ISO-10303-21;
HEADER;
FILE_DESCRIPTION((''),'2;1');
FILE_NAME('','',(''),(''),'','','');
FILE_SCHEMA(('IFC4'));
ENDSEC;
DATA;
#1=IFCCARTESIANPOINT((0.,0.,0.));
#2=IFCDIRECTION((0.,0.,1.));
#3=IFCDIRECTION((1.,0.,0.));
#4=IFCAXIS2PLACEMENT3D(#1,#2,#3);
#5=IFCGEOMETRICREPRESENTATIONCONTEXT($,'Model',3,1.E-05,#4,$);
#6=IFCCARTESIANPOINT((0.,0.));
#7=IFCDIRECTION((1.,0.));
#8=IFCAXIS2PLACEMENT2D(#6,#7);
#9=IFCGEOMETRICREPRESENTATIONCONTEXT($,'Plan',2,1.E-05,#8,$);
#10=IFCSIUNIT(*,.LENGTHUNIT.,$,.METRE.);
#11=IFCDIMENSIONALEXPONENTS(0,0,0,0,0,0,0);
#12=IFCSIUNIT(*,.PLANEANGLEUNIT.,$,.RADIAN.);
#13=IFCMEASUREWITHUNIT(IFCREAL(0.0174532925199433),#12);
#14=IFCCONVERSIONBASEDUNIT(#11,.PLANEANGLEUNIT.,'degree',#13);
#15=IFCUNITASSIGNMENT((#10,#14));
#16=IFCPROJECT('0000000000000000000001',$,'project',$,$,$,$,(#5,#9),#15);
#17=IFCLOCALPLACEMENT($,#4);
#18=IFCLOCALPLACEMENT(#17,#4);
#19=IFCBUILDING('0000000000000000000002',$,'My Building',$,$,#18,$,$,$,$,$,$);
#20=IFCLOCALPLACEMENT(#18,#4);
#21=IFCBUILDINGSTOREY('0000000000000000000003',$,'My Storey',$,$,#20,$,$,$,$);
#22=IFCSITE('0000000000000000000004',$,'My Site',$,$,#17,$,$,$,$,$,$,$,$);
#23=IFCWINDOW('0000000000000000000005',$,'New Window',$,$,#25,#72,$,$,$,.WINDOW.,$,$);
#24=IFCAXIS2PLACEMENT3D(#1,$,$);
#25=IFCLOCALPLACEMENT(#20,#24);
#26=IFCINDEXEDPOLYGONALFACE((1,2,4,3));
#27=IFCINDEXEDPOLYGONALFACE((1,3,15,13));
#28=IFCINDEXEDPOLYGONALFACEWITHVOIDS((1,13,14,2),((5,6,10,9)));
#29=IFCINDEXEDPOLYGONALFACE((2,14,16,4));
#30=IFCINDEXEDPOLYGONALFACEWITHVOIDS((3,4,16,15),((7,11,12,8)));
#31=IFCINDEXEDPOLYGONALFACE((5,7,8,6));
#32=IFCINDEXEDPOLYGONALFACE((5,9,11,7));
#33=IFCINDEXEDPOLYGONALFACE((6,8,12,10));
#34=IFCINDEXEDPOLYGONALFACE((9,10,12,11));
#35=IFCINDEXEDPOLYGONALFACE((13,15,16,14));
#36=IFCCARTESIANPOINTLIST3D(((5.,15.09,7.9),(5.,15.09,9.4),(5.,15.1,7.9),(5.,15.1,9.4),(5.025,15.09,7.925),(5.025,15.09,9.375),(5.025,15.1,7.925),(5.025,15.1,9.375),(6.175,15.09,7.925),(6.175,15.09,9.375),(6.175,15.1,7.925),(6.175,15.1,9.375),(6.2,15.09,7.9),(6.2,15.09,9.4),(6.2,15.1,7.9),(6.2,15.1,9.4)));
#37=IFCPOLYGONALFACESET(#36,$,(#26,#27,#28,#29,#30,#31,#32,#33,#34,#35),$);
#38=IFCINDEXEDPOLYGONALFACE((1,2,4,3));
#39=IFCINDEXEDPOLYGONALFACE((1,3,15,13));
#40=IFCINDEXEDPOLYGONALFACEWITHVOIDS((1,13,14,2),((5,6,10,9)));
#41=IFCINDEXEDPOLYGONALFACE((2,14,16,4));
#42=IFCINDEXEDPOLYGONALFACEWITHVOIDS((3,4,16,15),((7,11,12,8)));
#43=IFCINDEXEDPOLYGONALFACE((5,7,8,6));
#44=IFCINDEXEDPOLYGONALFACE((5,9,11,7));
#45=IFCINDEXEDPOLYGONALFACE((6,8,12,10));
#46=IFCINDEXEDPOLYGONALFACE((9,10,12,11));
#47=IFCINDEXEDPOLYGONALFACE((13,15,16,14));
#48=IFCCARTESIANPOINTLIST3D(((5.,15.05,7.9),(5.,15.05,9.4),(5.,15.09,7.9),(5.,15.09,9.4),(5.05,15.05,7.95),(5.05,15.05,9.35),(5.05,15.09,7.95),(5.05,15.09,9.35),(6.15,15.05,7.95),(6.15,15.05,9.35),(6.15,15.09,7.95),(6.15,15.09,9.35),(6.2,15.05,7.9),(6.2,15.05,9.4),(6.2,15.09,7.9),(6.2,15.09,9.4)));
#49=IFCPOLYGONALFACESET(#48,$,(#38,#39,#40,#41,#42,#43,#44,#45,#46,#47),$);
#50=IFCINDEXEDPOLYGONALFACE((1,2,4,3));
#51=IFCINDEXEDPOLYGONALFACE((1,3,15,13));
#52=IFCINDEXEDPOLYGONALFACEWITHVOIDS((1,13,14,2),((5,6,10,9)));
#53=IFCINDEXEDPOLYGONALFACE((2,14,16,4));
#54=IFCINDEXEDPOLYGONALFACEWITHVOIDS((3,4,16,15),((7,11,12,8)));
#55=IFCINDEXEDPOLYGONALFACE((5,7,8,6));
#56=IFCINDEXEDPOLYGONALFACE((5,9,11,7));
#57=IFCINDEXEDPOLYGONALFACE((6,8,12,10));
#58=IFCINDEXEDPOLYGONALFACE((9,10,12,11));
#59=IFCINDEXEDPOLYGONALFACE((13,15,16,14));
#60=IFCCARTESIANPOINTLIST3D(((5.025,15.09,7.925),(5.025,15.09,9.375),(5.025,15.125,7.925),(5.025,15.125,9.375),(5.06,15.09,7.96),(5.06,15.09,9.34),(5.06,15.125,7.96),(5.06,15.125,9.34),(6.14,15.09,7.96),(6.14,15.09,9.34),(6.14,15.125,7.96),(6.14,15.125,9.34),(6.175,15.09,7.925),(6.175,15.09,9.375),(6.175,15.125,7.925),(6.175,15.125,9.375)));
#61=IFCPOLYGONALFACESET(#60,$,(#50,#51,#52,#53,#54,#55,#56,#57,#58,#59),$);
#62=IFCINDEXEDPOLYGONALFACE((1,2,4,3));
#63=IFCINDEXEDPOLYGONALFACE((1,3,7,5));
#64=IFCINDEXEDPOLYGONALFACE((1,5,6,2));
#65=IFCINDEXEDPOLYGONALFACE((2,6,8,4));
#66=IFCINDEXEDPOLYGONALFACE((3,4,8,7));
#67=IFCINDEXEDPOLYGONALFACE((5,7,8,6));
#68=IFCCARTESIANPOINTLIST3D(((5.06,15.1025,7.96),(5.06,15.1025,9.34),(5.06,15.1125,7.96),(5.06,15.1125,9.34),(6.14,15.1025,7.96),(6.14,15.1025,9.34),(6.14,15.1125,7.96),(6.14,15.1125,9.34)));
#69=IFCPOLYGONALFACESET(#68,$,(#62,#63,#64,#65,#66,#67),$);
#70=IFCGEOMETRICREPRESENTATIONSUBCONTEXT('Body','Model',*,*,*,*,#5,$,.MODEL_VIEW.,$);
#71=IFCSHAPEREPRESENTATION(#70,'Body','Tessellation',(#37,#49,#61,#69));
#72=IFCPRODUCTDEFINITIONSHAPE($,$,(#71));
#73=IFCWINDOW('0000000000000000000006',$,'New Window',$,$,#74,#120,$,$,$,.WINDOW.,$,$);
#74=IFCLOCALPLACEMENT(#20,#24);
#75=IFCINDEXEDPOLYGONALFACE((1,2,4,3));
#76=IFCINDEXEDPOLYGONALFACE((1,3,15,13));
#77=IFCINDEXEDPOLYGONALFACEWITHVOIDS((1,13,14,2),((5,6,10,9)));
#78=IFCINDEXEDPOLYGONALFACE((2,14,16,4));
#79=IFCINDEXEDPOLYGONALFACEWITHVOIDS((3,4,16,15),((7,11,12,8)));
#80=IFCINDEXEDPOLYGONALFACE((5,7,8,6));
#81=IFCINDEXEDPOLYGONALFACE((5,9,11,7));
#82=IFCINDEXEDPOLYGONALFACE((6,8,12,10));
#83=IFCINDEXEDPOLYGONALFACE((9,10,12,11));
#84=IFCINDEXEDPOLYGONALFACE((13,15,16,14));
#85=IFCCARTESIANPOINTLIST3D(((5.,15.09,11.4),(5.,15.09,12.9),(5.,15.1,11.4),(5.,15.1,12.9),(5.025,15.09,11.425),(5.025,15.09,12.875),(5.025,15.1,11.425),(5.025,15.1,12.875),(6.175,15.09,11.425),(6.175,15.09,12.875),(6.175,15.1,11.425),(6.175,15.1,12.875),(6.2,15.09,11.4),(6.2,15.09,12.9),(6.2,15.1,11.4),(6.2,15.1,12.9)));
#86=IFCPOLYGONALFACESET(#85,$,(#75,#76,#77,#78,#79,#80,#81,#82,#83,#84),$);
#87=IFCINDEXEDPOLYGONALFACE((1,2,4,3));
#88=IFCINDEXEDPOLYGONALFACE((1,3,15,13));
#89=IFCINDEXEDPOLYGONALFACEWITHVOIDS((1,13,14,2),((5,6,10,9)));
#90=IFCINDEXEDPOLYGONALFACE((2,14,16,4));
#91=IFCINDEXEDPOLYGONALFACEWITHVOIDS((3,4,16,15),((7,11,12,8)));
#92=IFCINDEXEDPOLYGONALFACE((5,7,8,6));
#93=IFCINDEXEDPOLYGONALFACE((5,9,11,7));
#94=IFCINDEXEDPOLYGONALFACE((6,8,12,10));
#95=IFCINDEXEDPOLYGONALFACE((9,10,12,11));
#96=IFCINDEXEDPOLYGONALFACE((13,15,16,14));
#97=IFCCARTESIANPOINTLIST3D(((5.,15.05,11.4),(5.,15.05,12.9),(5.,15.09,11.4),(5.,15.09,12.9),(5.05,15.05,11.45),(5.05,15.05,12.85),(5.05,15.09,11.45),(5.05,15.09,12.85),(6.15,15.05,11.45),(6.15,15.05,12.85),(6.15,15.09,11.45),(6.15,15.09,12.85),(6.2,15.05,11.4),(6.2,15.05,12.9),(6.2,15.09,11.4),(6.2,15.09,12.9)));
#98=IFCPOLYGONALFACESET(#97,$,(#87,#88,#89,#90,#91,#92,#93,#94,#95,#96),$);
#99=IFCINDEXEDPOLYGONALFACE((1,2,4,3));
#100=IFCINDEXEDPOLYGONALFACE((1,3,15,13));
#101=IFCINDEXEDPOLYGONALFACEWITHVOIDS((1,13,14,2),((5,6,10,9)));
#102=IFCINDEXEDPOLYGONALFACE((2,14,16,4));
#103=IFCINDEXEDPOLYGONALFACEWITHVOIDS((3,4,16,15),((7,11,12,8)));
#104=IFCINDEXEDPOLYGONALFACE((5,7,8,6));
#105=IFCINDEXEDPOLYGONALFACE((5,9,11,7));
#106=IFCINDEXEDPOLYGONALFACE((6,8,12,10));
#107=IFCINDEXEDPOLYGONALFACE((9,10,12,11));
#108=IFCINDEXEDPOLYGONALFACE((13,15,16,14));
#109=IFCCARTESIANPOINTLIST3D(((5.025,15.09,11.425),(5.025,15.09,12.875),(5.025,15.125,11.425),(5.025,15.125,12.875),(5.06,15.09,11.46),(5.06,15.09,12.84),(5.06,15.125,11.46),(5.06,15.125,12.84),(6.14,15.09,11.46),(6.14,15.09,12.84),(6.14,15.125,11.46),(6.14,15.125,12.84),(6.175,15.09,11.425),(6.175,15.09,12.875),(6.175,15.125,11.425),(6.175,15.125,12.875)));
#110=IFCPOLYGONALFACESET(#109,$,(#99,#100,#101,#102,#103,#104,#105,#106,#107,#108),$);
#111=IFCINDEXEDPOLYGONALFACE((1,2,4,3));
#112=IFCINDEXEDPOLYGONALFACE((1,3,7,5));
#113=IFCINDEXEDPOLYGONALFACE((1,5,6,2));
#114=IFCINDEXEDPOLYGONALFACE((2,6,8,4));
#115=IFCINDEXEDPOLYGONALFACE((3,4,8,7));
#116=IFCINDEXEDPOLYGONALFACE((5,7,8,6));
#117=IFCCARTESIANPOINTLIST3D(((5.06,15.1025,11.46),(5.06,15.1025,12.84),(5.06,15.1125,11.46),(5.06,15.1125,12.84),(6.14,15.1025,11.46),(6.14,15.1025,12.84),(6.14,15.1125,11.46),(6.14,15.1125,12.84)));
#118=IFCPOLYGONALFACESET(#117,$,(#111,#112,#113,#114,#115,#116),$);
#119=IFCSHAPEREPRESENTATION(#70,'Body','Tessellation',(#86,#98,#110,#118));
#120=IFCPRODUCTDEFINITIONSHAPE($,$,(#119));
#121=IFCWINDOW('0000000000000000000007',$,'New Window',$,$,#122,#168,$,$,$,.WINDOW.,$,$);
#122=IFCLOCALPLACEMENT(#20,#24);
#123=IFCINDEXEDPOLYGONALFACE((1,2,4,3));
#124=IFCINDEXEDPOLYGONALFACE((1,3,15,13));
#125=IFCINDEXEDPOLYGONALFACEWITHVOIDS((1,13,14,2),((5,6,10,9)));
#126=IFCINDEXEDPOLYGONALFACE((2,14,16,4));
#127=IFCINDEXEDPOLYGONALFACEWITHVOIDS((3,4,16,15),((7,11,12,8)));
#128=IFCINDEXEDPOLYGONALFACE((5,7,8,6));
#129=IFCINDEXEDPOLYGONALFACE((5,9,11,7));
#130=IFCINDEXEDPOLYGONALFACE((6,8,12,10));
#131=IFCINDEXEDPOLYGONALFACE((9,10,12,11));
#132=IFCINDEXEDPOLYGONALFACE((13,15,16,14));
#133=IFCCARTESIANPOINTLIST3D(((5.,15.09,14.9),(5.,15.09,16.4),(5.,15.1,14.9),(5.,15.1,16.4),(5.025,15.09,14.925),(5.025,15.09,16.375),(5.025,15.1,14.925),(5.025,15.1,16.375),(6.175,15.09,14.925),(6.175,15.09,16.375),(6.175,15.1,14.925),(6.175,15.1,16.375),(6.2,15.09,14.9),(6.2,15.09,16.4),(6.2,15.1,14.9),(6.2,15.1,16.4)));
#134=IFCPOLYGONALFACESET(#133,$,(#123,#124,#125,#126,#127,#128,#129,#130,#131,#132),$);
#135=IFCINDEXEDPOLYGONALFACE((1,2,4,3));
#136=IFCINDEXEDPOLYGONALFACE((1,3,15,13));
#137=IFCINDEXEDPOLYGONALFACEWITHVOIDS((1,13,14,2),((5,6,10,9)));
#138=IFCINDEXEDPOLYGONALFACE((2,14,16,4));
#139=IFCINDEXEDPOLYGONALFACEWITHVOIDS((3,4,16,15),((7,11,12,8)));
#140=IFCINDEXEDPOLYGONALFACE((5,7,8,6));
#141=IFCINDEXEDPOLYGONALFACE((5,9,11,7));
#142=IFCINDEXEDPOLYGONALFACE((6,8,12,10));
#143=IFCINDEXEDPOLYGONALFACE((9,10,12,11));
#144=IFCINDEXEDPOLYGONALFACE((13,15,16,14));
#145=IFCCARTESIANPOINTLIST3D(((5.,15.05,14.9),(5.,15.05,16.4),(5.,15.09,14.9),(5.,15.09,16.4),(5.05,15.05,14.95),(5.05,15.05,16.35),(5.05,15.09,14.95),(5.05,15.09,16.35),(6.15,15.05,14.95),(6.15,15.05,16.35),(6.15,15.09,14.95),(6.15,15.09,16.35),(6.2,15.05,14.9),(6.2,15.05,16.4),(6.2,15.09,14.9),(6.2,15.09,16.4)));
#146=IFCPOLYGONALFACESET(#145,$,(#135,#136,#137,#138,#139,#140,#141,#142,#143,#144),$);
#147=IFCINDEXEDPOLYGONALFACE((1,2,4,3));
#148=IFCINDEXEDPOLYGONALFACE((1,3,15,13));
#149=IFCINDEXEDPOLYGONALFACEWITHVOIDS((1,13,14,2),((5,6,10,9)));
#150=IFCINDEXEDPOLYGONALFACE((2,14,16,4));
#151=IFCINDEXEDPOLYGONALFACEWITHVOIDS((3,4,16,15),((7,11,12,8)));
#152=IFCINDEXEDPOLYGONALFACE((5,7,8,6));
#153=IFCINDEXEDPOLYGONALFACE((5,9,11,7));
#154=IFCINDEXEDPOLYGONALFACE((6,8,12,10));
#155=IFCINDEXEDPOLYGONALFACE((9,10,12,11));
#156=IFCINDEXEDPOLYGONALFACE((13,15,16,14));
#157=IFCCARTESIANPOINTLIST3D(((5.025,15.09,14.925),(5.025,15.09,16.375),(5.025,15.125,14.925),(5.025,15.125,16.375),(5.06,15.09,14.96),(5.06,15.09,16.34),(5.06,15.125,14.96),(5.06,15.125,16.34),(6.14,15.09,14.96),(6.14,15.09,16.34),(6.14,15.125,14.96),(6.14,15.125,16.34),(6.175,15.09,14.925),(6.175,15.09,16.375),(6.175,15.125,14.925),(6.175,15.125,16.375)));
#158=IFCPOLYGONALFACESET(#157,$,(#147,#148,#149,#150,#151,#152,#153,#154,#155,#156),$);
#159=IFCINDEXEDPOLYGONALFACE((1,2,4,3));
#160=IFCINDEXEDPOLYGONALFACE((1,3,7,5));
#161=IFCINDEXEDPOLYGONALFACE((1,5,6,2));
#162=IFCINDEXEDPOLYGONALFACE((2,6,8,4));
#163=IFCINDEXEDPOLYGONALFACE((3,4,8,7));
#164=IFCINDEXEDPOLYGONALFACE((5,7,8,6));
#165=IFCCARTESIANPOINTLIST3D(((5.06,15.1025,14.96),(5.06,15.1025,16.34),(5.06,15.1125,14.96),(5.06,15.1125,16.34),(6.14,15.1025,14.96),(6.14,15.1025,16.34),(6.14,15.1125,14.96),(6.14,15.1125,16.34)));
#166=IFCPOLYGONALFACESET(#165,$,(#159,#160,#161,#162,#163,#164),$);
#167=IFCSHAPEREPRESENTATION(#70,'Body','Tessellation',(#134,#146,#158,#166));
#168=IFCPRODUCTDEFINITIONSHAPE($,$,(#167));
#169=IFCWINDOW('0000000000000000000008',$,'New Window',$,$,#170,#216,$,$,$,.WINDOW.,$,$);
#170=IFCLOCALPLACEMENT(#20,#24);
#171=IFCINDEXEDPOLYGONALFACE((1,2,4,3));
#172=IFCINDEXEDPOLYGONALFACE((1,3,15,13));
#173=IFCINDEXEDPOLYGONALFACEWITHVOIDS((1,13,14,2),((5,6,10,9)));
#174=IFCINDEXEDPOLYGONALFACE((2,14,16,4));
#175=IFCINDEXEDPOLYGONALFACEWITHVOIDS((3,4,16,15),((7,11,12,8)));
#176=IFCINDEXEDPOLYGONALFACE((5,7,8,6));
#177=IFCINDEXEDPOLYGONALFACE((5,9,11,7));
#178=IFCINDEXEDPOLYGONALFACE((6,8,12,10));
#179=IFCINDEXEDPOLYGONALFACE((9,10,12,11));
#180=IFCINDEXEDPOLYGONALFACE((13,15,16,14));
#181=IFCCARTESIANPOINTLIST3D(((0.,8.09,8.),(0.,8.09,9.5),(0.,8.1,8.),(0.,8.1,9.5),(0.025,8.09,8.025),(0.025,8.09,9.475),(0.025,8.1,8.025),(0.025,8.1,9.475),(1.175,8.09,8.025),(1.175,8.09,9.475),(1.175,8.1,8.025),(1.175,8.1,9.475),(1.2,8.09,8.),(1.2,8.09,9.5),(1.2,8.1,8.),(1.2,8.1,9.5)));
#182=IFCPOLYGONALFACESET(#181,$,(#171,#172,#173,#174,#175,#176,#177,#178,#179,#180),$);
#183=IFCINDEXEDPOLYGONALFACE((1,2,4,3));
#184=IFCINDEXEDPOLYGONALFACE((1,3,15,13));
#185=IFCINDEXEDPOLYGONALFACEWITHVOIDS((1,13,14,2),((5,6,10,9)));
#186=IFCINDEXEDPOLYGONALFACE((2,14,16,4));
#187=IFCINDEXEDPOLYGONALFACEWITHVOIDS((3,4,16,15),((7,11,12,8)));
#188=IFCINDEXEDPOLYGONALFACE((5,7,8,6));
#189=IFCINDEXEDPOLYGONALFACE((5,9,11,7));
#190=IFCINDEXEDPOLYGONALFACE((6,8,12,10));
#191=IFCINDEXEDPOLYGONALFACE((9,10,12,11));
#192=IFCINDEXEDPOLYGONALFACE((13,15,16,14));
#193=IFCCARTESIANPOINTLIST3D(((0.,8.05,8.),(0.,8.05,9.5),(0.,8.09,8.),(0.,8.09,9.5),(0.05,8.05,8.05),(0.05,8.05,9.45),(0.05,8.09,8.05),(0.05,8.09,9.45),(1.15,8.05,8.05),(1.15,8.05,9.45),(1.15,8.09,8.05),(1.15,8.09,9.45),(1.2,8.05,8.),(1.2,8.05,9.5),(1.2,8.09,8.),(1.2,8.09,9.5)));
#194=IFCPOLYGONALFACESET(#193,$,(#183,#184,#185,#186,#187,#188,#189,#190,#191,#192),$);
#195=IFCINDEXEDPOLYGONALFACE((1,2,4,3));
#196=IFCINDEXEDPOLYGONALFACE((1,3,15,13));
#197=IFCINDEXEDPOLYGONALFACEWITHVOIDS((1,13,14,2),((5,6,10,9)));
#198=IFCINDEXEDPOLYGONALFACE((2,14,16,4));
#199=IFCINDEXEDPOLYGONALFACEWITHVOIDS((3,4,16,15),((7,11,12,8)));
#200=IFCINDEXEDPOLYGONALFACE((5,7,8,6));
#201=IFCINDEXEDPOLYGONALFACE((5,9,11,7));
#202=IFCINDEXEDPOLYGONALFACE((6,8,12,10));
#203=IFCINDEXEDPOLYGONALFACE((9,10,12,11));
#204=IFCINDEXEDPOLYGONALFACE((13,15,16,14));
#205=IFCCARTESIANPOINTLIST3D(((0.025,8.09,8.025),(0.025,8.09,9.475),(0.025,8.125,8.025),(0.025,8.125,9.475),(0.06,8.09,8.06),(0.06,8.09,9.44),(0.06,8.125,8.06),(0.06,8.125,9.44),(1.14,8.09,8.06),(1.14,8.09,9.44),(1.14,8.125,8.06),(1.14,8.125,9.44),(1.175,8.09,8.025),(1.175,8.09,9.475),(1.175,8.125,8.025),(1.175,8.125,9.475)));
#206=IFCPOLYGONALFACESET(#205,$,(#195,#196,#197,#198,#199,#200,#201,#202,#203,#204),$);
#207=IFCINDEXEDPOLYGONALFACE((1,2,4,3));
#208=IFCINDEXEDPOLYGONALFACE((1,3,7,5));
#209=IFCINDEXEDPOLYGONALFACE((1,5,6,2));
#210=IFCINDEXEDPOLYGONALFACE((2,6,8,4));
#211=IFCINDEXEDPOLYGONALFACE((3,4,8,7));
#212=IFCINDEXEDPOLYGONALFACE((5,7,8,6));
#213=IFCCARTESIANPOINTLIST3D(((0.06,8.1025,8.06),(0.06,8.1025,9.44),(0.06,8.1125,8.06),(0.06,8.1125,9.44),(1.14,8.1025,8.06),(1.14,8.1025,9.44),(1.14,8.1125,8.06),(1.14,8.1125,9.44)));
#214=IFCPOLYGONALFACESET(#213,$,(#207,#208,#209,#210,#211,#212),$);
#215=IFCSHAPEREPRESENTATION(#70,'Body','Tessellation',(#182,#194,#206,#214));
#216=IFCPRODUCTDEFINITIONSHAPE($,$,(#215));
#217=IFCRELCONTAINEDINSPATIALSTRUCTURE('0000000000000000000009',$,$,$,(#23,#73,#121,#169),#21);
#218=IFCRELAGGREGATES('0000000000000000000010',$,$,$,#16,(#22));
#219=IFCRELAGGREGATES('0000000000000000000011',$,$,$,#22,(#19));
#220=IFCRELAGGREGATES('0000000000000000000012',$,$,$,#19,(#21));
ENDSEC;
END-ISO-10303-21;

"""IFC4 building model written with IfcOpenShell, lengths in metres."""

from ifc_helpers import new_model, entity, si_unit, converted_unit, frame, origin_with_axes, origin_2d_with_axis, place, context, subcontext, project, spatial, line, indexed_curve, outline, extrude, element, save


model = new_model("IFC4")

# Units and contexts
model_context = context("Model", 3, precision=1e-05, world=origin_with_axes())
plan_context = context("Plan", 2, precision=1e-05, world=origin_2d_with_axis())
body_context = subcontext(model_context, "Body", "Model", "MODEL_VIEW")
ifc_project = project(units=[si_unit("LENGTHUNIT", "METRE"), converted_unit("PLANEANGLEUNIT", "degree", entity("IfcReal", 0.0174532925199433), si_unit("PLANEANGLEUNIT", "RADIAN"), dimensions=[0, 0, 0, 0, 0, 0, 0])], contexts=[model_context, plan_context])

# Site, building, storey
site_placement = place(None, origin_with_axes())
site = spatial("IfcSite", under=ifc_project, at=site_placement, Name="My Site")
building_placement = place(site_placement, origin_with_axes())
building = spatial("IfcBuilding", under=site, at=building_placement, Name="My Building")
storey_placement = place(building_placement, origin_with_axes())
storey = spatial("IfcBuildingStorey", under=building, at=storey_placement, Name="My Storey")

# Windows
for number, where, z_axis, x_axis, name in (
    (1, (5.0, 15.0, 7.9), (0.0, 0.0, 1.0), (1.0, 0.0, 0.0), "New Window"),
    (2, (5.0, 15.0, 11.4), (0.0, 0.0, 1.0), (1.0, 0.0, 0.0), "New Window"),
    (3, (5.0, 15.0, 14.9), (0.0, 0.0, 1.0), (1.0, 0.0, 0.0), "New Window"),
):
    element("IfcWindow", number, at=place(storey_placement, frame(where, z_axis=z_axis, x_axis=x_axis)), inside=storey, Name=name, PredefinedType="WINDOW", context=body_context, shape_type="SweptSolid", body=[
        extrude(outline(indexed_curve([(0.0, 0.0), (1.2, 0.0), (1.2, 1.5), (0.0, 1.5)], segments=[line(1, 2, 3, 4, 1)]), holes=[indexed_curve([(0.025, 0.025), (1.175, 0.025), (1.175, 1.475), (0.025, 1.475)], segments=[line(1, 2, 3, 4, 1)])]), frame((0.0, 0.09, 0.0), z_axis=(0.0, -1.0, 0.0), x_axis=(1.0, 0.0, 0.0)), (0.0, 0.0, -1.0), 0.01),
        extrude(outline(indexed_curve([(0.0, 0.0), (1.2, 0.0), (1.2, 1.5), (0.0, 1.5)], segments=[line(1, 2, 3, 4, 1)]), holes=[indexed_curve([(0.05, 0.05), (1.15, 0.05), (1.15, 1.45), (0.05, 1.45)], segments=[line(1, 2, 3, 4, 1)])]), frame((0.0, 0.05, 0.0), z_axis=(0.0, -1.0, 0.0), x_axis=(1.0, 0.0, 0.0)), (0.0, 0.0, -1.0), 0.04),
        extrude(outline(indexed_curve([(0.0, 0.0), (1.15, 0.0), (1.15, 1.45), (0.0, 1.45)], segments=[line(1, 2, 3, 4, 1)]), holes=[indexed_curve([(0.035, 0.035), (1.115, 0.035), (1.115, 1.415), (0.035, 1.415)], segments=[line(1, 2, 3, 4, 1)])]), frame((0.025, 0.09, 0.025), z_axis=(0.0, -1.0, 0.0), x_axis=(1.0, 0.0, 0.0)), (0.0, 0.0, -1.0), 0.035),
        extrude(outline(indexed_curve([(0.035, 0.035), (1.115, 0.035), (1.115, 1.415), (0.035, 1.415)], segments=[line(1, 2, 3, 4, 1)])), frame((0.025, 0.1025, 0.025), z_axis=(0.0, -1.0, 0.0), x_axis=(1.0, 0.0, 0.0)), (0.0, 0.0, -1.0), 0.01),
    ])

# Window
for number, where, z_axis, x_axis, name in (
    (4, (0.0, 8.0, 8.0), (0.0, 0.0, 1.0), (1.0, 0.0, 0.0), "New Window"),
):
    element("IfcWindow", number, at=place(storey_placement, frame(where, z_axis=z_axis, x_axis=x_axis)), inside=storey, Name=name, PredefinedType="WINDOW", context=body_context, shape_type="SweptSolid", body=[
        extrude(outline(indexed_curve([(0.0, 0.0), (1.2, 0.0), (1.2, 1.5), (0.0, 1.5)], segments=[line(1, 2, 3, 4, 1)]), holes=[indexed_curve([(0.025, 0.025), (1.175, 0.025), (1.175, 1.475), (0.025, 1.475)], segments=[line(1, 2, 3, 4, 1)])]), frame((0.0, 0.09, 0.0), z_axis=(0.0, -1.0, 0.0), x_axis=(1.0, 0.0, 0.0)), (0.0, 0.0, -1.0), 0.01),
        extrude(outline(indexed_curve([(0.0, 0.0), (1.2, 0.0), (1.2, 1.5), (0.0, 1.5)], segments=[line(1, 2, 3, 4, 1)]), holes=[indexed_curve([(0.05, 0.05), (1.15, 0.05), (1.15, 1.45), (0.05, 1.45)], segments=[line(1, 2, 3, 4, 1)])]), frame((0.0, 0.05, 0.0), z_axis=(0.0, -1.0, 0.0), x_axis=(1.0, 0.0, 0.0)), (0.0, 0.0, -1.0), 0.04),
        extrude(outline(indexed_curve([(0.0, 0.0), (1.15, 0.0), (1.15, 1.45), (0.0, 1.45)], segments=[line(1, 2, 3, 4, 1)]), holes=[indexed_curve([(0.035, 0.035), (1.115, 0.035), (1.115, 1.415), (0.035, 1.415)], segments=[line(1, 2, 3, 4, 1)])]), frame((0.025, 0.09, 0.025), z_axis=(0.0, -1.0, 0.0), x_axis=(1.0, 0.0, 0.0)), (0.0, 0.0, -1.0), 0.035),
        extrude(outline(indexed_curve([(0.035, 0.035), (1.115, 0.035), (1.115, 1.415), (0.035, 1.415)], segments=[line(1, 2, 3, 4, 1)])), frame((0.025, 0.1025, 0.025), z_axis=(0.0, -1.0, 0.0), x_axis=(1.0, 0.0, 0.0)), (0.0, 0.0, -1.0), 0.01),
    ])

save(model, "model.ifc")
